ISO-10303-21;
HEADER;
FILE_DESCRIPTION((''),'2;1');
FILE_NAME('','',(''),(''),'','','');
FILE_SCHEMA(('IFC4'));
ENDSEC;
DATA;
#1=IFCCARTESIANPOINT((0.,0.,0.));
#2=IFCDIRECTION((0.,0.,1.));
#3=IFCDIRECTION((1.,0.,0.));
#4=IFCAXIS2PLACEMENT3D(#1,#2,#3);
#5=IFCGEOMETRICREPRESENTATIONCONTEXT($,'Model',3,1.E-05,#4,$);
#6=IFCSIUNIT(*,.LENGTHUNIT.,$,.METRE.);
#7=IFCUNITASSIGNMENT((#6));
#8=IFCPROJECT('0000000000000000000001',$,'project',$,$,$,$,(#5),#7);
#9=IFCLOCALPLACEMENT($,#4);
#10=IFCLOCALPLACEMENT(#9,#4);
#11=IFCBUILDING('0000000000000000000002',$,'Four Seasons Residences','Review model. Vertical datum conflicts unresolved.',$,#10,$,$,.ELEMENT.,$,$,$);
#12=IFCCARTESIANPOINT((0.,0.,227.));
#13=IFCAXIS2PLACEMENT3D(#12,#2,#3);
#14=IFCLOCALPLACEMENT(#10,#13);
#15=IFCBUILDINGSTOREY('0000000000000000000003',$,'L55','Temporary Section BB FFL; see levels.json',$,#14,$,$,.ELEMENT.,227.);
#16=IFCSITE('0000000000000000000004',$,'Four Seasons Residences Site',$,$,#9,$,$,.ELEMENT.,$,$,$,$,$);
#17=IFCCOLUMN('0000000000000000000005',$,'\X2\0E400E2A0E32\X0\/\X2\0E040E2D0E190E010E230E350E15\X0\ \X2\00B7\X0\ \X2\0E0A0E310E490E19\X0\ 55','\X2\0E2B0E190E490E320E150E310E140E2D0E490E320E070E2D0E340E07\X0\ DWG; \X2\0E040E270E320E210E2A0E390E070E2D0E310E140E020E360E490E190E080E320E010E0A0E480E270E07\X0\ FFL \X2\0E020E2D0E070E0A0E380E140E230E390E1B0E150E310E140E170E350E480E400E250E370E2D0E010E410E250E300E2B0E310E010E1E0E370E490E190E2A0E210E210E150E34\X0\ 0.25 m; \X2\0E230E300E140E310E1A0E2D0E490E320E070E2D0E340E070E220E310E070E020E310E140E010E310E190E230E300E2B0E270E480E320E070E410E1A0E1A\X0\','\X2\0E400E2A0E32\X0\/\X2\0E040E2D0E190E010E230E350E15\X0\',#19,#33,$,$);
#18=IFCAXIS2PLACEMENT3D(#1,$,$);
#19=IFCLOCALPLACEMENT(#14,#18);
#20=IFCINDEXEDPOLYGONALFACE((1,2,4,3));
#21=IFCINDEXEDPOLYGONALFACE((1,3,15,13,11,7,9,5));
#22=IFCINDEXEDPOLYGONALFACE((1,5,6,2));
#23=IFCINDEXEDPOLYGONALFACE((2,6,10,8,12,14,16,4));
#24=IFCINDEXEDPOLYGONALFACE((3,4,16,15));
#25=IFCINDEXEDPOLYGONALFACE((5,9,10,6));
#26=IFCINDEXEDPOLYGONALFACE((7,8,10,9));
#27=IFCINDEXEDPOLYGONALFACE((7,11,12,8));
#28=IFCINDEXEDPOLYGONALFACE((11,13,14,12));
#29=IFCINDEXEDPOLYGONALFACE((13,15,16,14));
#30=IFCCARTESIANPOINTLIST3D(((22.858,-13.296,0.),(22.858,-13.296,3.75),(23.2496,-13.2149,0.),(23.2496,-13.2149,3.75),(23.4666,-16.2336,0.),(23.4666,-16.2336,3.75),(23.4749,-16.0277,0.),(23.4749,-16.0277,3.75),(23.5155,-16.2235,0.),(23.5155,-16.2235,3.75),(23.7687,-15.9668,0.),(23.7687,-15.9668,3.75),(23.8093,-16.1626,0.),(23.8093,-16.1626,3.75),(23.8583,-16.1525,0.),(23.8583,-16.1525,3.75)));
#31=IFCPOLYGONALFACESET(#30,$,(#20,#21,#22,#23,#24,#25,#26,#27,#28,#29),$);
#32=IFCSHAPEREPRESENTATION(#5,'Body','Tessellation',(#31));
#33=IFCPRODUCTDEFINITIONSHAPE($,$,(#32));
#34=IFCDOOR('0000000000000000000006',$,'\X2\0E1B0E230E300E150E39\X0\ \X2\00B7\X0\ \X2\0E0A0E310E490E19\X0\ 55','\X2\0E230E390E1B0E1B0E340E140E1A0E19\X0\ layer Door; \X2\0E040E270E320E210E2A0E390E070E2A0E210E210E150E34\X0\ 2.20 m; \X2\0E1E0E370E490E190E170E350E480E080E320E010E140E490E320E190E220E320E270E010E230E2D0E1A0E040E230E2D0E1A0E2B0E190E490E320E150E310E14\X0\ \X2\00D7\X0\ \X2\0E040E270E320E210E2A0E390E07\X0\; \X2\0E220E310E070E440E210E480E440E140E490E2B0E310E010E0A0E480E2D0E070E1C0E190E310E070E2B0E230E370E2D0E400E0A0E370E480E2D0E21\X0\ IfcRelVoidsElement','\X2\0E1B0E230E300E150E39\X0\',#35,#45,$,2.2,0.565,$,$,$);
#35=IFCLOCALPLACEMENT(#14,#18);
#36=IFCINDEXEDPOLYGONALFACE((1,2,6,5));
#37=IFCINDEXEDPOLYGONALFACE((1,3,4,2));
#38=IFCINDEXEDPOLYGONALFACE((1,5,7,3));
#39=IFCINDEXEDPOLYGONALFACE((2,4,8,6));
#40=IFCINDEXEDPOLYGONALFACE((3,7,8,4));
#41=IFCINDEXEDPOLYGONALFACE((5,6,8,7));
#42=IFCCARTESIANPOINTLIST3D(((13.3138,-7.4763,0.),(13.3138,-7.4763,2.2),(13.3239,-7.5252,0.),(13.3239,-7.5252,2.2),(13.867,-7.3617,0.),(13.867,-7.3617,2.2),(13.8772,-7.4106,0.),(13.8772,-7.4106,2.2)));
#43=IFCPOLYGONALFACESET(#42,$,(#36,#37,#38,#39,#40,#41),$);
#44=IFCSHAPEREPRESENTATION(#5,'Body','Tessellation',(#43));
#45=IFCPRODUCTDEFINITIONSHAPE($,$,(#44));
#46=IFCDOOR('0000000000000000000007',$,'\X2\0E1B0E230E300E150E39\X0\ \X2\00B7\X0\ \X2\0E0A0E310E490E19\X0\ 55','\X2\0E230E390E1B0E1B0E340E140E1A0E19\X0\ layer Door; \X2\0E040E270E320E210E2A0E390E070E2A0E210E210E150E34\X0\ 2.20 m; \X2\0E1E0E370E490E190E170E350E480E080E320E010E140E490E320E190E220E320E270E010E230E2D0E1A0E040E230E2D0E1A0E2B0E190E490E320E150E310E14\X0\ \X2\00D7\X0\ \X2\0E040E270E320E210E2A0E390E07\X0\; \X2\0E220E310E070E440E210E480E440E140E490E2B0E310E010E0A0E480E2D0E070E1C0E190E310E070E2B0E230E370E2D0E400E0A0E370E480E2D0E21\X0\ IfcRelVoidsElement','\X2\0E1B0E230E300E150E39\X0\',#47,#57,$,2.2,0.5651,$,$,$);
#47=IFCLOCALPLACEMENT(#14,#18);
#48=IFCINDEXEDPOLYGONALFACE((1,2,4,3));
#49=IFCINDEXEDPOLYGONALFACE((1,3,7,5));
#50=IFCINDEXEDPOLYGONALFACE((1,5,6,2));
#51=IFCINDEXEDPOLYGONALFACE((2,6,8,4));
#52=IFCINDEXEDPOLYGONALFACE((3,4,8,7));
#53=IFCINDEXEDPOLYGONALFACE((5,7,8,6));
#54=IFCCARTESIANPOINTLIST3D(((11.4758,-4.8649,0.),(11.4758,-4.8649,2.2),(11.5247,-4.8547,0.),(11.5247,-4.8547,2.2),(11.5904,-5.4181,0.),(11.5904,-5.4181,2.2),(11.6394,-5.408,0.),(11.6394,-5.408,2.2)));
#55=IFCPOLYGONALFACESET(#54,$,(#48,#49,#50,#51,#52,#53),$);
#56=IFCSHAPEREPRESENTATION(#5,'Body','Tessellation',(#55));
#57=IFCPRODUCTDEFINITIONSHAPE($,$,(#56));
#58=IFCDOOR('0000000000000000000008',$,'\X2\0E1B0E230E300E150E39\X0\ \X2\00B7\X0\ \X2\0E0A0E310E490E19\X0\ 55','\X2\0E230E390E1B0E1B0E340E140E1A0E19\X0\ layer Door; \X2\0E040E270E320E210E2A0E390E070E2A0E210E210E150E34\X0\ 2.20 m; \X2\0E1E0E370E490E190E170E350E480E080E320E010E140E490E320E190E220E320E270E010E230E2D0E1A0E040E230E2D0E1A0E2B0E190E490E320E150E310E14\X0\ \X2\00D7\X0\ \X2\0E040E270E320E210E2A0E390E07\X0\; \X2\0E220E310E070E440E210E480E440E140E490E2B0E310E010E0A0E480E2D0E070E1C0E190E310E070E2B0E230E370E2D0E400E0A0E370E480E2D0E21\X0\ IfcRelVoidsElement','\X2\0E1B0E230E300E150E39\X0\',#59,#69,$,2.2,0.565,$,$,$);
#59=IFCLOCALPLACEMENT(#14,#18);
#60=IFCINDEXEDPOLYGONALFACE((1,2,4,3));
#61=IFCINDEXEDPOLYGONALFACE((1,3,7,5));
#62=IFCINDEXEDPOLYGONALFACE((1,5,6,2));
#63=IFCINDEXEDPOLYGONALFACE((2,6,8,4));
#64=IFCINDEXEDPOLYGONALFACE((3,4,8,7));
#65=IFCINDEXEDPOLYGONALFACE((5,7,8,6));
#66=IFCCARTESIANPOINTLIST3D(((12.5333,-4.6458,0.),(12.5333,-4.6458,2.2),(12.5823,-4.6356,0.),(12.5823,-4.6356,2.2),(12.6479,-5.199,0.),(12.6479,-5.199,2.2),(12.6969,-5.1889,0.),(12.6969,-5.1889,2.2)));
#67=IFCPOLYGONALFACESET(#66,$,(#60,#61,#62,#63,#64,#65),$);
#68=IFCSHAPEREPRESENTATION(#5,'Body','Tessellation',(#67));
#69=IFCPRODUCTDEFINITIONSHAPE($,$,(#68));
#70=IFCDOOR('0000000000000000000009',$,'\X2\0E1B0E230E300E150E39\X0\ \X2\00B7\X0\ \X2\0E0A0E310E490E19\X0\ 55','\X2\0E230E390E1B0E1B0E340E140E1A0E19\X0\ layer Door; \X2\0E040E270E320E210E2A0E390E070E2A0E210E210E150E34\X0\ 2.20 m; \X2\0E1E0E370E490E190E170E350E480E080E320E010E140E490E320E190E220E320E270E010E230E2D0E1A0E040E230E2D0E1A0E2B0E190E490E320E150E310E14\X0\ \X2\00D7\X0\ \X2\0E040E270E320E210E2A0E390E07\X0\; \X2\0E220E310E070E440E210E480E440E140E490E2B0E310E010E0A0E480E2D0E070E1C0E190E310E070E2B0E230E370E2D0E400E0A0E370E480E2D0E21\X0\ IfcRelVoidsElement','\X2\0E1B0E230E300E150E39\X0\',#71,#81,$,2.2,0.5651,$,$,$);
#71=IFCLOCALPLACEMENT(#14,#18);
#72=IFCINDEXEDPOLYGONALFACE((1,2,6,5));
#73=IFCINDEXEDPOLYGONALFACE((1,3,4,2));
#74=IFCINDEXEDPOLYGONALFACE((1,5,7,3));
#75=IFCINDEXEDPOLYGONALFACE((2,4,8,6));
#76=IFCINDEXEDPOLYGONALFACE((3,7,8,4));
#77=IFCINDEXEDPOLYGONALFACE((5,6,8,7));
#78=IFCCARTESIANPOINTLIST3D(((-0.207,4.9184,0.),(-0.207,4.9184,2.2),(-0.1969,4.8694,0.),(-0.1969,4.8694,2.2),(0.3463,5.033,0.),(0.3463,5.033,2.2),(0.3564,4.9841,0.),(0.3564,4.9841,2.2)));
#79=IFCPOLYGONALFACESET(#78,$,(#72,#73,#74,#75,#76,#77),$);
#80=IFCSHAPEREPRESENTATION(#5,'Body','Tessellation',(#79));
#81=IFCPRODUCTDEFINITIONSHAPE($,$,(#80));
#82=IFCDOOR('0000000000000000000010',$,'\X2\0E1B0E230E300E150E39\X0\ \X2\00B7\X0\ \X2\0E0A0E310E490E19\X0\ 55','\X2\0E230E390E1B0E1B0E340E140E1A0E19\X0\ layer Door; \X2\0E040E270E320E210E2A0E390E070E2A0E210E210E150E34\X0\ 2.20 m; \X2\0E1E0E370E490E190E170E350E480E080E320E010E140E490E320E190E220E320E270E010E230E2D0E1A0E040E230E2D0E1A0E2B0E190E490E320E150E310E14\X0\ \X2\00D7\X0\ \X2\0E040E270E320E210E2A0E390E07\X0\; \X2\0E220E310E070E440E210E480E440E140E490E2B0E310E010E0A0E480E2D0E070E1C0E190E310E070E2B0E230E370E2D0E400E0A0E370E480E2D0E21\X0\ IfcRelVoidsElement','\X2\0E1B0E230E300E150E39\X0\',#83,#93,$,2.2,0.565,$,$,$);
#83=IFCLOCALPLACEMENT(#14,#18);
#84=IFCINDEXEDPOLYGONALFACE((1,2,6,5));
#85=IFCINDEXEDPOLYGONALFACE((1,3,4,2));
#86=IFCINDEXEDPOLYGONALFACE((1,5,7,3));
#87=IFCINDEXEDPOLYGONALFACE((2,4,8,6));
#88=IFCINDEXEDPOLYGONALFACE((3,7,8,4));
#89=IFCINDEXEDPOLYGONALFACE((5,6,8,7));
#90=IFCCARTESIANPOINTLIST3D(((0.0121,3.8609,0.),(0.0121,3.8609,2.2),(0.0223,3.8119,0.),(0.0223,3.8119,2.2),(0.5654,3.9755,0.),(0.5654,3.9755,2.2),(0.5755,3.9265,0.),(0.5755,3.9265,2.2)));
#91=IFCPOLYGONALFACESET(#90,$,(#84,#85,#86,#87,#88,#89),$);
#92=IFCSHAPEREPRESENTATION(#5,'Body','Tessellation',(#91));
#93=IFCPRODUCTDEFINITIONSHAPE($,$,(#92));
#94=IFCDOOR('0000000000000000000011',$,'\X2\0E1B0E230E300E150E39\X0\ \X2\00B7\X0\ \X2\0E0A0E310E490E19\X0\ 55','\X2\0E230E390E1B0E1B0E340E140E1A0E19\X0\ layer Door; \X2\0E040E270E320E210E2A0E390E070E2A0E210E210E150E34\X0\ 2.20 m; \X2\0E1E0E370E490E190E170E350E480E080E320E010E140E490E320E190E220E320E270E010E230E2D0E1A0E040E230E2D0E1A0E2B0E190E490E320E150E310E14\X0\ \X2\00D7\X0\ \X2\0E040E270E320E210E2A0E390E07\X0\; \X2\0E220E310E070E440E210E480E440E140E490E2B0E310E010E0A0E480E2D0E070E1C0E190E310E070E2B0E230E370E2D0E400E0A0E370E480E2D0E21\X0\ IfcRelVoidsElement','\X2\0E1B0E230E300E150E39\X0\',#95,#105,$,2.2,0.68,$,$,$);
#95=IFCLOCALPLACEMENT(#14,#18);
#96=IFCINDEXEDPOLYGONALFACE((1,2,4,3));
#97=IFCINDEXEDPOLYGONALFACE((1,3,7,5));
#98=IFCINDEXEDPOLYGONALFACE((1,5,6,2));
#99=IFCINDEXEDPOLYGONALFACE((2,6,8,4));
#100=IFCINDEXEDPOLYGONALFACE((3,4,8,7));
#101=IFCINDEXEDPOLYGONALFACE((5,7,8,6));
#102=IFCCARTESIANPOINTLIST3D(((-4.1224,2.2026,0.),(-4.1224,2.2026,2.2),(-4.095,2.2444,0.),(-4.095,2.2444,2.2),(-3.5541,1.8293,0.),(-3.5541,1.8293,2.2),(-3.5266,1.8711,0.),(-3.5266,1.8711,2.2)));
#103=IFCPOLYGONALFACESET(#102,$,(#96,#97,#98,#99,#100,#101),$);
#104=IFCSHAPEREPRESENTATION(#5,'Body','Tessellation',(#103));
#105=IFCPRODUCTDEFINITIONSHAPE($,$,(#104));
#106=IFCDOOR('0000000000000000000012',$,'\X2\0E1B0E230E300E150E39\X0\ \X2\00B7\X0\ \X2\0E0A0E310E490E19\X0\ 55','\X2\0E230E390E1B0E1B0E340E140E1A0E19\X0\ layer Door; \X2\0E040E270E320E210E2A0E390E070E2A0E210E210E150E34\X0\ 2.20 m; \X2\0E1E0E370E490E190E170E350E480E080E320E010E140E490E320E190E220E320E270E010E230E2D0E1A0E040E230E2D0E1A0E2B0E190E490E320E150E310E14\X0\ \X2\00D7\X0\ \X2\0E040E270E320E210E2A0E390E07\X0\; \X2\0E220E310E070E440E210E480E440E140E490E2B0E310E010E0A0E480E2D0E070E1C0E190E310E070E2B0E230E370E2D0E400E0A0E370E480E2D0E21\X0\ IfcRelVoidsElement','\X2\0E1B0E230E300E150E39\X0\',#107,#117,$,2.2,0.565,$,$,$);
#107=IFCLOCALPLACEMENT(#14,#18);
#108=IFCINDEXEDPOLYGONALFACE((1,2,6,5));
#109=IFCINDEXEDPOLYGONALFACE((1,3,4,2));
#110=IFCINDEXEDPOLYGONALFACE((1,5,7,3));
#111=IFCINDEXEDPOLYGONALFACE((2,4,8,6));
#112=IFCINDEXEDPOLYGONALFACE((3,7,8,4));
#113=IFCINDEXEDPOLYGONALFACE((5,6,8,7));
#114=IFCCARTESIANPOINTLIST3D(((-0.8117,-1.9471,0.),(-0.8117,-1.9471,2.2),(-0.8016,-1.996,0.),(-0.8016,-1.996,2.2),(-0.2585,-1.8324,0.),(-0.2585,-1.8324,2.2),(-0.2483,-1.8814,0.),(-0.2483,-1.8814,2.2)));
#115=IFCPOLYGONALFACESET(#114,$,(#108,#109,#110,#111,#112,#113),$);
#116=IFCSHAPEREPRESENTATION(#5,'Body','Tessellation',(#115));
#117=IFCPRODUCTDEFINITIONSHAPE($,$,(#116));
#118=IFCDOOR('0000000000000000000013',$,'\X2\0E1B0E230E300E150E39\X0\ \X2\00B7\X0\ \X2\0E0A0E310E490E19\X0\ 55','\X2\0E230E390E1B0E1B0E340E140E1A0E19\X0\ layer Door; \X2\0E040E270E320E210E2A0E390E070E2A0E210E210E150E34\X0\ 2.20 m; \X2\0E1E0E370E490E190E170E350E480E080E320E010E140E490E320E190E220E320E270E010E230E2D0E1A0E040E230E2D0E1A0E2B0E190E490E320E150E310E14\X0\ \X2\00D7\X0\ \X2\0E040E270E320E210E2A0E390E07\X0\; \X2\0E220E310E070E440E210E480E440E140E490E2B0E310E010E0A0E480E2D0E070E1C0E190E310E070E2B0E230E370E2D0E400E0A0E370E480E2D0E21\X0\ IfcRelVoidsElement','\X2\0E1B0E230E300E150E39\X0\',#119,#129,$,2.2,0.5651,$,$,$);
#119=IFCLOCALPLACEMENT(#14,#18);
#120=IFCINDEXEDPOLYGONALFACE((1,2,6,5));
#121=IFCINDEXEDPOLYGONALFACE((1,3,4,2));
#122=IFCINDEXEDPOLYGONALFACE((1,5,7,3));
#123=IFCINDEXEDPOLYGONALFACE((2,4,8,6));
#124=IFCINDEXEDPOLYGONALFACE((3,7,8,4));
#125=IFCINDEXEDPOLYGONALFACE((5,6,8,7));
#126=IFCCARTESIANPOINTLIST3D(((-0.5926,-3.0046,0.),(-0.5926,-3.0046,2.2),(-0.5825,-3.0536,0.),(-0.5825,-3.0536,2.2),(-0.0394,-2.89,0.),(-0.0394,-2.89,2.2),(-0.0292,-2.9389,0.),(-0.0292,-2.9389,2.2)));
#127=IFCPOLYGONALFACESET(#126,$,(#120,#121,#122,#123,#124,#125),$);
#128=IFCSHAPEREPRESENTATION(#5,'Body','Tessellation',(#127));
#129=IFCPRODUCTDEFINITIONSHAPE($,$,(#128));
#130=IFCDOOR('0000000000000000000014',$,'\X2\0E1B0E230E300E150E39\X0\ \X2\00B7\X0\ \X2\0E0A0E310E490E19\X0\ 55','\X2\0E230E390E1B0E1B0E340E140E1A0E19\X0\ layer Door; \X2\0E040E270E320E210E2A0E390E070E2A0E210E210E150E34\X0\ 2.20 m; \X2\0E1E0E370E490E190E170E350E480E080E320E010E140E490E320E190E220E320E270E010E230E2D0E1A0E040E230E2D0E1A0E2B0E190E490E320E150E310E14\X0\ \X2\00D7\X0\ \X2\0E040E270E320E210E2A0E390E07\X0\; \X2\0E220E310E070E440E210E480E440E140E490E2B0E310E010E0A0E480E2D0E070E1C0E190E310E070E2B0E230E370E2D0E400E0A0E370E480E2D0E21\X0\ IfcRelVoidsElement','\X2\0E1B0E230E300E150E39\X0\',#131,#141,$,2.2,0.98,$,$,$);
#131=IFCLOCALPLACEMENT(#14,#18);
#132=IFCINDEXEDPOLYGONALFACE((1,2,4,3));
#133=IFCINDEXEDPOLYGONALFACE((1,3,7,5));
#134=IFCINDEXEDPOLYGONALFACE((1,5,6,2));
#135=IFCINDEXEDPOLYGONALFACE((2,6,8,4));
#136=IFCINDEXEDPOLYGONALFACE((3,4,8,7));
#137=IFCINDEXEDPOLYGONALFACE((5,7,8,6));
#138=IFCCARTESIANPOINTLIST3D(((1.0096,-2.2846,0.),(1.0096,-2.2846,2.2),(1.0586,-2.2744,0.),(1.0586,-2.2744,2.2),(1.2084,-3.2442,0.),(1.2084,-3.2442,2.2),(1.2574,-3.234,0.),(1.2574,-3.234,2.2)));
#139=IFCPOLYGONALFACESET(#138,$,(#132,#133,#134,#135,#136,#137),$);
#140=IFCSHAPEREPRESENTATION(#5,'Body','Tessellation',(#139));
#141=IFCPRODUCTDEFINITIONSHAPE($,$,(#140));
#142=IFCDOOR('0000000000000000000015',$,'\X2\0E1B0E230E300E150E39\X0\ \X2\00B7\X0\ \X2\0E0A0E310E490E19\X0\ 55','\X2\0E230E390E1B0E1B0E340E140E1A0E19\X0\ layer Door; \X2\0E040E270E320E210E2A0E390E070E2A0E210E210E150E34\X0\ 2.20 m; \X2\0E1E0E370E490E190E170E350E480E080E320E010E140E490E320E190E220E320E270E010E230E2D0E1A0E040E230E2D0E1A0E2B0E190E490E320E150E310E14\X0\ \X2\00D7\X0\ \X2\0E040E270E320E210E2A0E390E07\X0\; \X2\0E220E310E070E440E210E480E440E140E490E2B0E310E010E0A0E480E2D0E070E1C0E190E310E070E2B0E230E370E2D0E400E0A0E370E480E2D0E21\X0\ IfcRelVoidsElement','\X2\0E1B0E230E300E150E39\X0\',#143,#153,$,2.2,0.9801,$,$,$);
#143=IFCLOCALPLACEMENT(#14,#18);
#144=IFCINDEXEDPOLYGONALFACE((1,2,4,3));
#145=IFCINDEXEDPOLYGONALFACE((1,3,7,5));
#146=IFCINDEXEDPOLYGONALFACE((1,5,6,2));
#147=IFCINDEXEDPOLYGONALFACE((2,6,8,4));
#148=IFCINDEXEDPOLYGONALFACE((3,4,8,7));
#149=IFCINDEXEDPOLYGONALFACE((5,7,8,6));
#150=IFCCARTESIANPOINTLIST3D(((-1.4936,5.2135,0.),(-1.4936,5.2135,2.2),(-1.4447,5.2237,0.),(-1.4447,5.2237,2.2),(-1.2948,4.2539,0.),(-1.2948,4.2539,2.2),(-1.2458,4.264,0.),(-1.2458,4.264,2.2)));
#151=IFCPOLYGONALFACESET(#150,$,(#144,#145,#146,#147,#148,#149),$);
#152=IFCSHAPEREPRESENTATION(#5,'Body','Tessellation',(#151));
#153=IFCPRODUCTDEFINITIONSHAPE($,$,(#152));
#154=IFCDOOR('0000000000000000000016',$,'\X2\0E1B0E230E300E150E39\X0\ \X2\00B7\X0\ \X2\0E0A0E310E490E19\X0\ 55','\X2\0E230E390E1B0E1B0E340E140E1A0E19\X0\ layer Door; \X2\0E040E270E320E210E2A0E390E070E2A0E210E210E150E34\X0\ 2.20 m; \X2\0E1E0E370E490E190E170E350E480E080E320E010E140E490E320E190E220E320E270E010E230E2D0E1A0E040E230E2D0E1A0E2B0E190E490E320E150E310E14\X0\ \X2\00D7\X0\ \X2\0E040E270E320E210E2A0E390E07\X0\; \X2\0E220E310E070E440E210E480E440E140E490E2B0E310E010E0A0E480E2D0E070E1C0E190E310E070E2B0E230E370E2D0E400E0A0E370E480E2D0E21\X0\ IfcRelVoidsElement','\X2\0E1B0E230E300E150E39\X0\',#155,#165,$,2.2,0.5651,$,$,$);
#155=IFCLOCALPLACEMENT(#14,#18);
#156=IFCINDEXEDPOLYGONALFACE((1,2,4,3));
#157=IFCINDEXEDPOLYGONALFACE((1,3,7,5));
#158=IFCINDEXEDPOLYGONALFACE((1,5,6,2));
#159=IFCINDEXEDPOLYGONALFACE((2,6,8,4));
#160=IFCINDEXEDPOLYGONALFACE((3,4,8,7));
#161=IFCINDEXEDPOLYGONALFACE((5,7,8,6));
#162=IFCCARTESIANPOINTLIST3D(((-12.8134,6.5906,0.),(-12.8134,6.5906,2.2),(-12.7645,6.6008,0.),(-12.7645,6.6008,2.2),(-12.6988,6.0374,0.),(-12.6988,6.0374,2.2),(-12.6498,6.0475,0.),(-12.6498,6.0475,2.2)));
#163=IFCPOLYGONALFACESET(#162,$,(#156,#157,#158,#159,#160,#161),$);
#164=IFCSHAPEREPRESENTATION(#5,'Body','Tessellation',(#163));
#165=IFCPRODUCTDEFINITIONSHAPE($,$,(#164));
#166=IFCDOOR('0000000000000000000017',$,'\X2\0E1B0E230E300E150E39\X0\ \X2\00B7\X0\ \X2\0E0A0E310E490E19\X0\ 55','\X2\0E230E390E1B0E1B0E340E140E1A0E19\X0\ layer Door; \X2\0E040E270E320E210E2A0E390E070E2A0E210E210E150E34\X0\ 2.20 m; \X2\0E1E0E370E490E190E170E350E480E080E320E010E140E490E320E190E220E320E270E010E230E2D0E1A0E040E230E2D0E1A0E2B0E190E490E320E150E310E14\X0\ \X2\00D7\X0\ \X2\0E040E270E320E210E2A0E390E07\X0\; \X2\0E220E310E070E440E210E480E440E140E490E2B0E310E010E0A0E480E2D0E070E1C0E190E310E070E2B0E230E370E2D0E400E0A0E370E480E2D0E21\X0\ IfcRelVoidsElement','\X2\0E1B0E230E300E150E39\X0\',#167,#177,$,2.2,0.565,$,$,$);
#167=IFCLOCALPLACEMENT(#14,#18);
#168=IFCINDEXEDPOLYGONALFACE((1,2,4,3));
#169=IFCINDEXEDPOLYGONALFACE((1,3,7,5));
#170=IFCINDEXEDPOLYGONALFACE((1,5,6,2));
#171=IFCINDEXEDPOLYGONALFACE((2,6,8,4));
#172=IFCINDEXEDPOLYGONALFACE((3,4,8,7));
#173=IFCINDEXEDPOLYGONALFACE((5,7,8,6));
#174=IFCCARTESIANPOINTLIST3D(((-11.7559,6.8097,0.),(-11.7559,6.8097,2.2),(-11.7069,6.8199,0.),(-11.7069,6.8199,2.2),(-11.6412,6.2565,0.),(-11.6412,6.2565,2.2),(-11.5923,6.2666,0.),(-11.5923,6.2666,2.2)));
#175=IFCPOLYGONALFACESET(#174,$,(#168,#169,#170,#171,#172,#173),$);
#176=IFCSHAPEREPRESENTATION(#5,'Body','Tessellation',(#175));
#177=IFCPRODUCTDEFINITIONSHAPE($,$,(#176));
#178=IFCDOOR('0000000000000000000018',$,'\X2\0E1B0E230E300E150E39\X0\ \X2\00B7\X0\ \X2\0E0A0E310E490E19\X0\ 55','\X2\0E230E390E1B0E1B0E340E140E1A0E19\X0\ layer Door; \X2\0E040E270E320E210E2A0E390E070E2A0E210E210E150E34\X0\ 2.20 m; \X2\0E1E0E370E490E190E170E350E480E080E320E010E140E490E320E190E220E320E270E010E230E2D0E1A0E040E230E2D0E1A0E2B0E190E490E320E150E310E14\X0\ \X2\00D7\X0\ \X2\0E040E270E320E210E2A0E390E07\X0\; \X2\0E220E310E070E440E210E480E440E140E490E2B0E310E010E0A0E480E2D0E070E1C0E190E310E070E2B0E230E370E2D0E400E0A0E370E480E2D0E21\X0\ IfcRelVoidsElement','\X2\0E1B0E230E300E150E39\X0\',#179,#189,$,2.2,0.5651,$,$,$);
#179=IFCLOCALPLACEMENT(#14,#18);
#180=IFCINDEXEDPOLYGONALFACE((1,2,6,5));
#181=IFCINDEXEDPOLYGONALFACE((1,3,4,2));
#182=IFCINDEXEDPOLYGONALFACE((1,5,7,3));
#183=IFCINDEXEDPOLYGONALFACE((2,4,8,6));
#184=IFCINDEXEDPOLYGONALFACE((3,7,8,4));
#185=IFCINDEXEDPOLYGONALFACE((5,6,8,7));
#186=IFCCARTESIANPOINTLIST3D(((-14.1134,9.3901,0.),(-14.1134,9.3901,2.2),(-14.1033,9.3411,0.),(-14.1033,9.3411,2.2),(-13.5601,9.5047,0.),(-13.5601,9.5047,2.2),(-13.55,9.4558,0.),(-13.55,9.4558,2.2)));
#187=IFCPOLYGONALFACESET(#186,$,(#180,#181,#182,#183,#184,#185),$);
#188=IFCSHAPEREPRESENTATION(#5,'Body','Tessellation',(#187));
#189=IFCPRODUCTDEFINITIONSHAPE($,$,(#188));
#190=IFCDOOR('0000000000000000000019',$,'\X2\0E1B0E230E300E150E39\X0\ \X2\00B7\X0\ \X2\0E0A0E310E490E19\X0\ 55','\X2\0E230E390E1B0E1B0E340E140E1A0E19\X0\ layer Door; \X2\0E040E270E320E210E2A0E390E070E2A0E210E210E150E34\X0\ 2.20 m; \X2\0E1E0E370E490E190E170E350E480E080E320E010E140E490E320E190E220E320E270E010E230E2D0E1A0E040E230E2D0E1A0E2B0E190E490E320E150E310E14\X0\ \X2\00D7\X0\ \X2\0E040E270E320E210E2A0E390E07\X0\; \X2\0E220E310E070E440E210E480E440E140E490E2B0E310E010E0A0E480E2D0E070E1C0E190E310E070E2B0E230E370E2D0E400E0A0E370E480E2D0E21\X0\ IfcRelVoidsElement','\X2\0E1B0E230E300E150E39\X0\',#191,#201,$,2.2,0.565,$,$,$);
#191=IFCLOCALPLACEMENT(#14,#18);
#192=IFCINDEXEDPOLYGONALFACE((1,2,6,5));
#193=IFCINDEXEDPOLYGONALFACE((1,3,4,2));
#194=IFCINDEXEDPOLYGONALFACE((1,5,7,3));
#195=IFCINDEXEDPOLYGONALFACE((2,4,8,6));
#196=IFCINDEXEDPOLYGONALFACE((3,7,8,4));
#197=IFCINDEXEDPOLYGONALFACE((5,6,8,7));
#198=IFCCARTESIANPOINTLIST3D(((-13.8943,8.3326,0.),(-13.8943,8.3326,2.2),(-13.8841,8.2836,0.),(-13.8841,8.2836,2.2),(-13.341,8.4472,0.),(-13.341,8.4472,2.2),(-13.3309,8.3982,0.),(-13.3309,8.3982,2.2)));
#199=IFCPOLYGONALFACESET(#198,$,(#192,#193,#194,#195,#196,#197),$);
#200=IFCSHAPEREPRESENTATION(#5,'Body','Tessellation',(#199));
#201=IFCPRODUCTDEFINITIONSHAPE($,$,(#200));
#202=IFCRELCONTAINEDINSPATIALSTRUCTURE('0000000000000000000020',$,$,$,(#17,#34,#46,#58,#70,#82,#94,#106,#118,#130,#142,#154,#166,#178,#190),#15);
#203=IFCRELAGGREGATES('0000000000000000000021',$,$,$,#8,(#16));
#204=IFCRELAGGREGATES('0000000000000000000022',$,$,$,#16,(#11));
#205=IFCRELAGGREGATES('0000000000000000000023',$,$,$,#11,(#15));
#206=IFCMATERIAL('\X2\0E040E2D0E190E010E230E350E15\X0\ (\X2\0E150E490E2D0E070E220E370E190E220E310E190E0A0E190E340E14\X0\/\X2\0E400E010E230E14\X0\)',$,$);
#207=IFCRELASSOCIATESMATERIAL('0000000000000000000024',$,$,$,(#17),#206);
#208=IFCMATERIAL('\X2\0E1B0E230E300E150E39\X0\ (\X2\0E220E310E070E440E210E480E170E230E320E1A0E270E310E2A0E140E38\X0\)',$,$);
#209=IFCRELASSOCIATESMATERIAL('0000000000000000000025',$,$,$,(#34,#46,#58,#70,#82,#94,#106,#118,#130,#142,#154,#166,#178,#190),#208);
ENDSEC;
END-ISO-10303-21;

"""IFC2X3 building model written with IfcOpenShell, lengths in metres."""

from ifc_helpers import new_model, si_unit, frame, origin_with_axes, place, context, project, spatial, polyline, outline, extrude, material, element, save


model = new_model("IFC2X3")

# Units and contexts
model_context = context("Model", 3, precision=1e-05, world=origin_with_axes())
ifc_project = project(units=[si_unit("LENGTHUNIT", "METRE")], contexts=[model_context])

# Site, building, storey
site_placement = place(None, origin_with_axes())
site = spatial("IfcSite", under=ifc_project, at=site_placement, Name="Four Seasons Residences Site", CompositionType="ELEMENT")
building_placement = place(site_placement, origin_with_axes())
building = spatial("IfcBuilding", under=site, at=building_placement, Name="Four Seasons Residences", Description="Review model. Vertical datum conflicts unresolved.", CompositionType="ELEMENT")
storey_placement = place(building_placement, frame((0.0, 0.0, 227.0), z_axis=(0.0, 0.0, 1.0), x_axis=(1.0, 0.0, 0.0)))
storey = spatial("IfcBuildingStorey", under=building, at=storey_placement, Name="L55", Description="Temporary Section BB FFL; see levels.json", CompositionType="ELEMENT", Elevation=227.0)

# Column
ifc_material_1 = material(Name="คอนกรีต (ต้องยืนยันชนิด/เกรด)")
column_placement = place(storey_placement, origin_with_axes())
element("IfcColumn", 1, at=column_placement, inside=storey, material=ifc_material_1, Name="เสา/คอนกรีต · ชั้น 55", Description="หน้าตัดอ้างอิง DWG; ความสูงอัดขึ้นจากช่วง FFL ของชุดรูปตัดที่เลือกและหักพื้นสมมติ 0.25 m; ระดับอ้างอิงยังขัดกันระหว่างแบบ", ObjectType="เสา/คอนกรีต", context=model_context, shape_type="SweptSolid", body=[
    extrude(outline(polyline([(23.8583, -16.1525), (23.8093, -16.1626), (23.7687, -15.9668), (23.4749, -16.0277), (23.5155, -16.2235), (23.4666, -16.2336), (22.858, -13.296), (23.2496, -13.2149), (23.8583, -16.1525)])), origin_with_axes(), (0.0, 0.0, 1.0), 3.75),
])

# Doors
ifc_material_2 = material(Name="ประตู (ยังไม่ทราบวัสดุ)")
door_1_placement = place(storey_placement, origin_with_axes())
element("IfcDoor", 2, at=door_1_placement, inside=storey, material=ifc_material_2, Name="ประตู · ชั้น 55", Description="รูปปิดบน layer Door; ความสูงสมมติ 2.20 m; พื้นที่จากด้านยาวกรอบครอบหน้าตัด × ความสูง; ยังไม่ได้หักช่องผนังหรือเชื่อม IfcRelVoidsElement", ObjectType="ประตู", OverallHeight=2.2, OverallWidth=0.565, context=model_context, shape_type="SweptSolid", body=[
    extrude(outline(polyline([(13.3239, -7.5252), (13.8772, -7.4106), (13.867, -7.3617), (13.3138, -7.4763), (13.3239, -7.5252)])), origin_with_axes(), (0.0, 0.0, 1.0), 2.2),
])
door_2_placement = place(storey_placement, origin_with_axes())
element("IfcDoor", 3, at=door_2_placement, inside=storey, material=ifc_material_2, Name="ประตู · ชั้น 55", Description="รูปปิดบน layer Door; ความสูงสมมติ 2.20 m; พื้นที่จากด้านยาวกรอบครอบหน้าตัด × ความสูง; ยังไม่ได้หักช่องผนังหรือเชื่อม IfcRelVoidsElement", ObjectType="ประตู", OverallHeight=2.2, OverallWidth=0.5651, context=model_context, shape_type="SweptSolid", body=[
    extrude(outline(polyline([(11.4758, -4.8649), (11.5904, -5.4181), (11.6394, -5.408), (11.5247, -4.8547), (11.4758, -4.8649)])), origin_with_axes(), (0.0, 0.0, 1.0), 2.2),
])
door_3_placement = place(storey_placement, origin_with_axes())
element("IfcDoor", 4, at=door_3_placement, inside=storey, material=ifc_material_2, Name="ประตู · ชั้น 55", Description="รูปปิดบน layer Door; ความสูงสมมติ 2.20 m; พื้นที่จากด้านยาวกรอบครอบหน้าตัด × ความสูง; ยังไม่ได้หักช่องผนังหรือเชื่อม IfcRelVoidsElement", ObjectType="ประตู", OverallHeight=2.2, OverallWidth=0.565, context=model_context, shape_type="SweptSolid", body=[
    extrude(outline(polyline([(12.5823, -4.6356), (12.6969, -5.1889), (12.6479, -5.199), (12.5333, -4.6458), (12.5823, -4.6356)])), origin_with_axes(), (0.0, 0.0, 1.0), 2.2),
])
door_4_placement = place(storey_placement, origin_with_axes())
element("IfcDoor", 5, at=door_4_placement, inside=storey, material=ifc_material_2, Name="ประตู · ชั้น 55", Description="รูปปิดบน layer Door; ความสูงสมมติ 2.20 m; พื้นที่จากด้านยาวกรอบครอบหน้าตัด × ความสูง; ยังไม่ได้หักช่องผนังหรือเชื่อม IfcRelVoidsElement", ObjectType="ประตู", OverallHeight=2.2, OverallWidth=0.5651, context=model_context, shape_type="SweptSolid", body=[
    extrude(outline(polyline([(-0.207, 4.9184), (0.3463, 5.033), (0.3564, 4.9841), (-0.1969, 4.8694), (-0.207, 4.9184)])), origin_with_axes(), (0.0, 0.0, 1.0), 2.2),
])
door_5_placement = place(storey_placement, origin_with_axes())
element("IfcDoor", 6, at=door_5_placement, inside=storey, material=ifc_material_2, Name="ประตู · ชั้น 55", Description="รูปปิดบน layer Door; ความสูงสมมติ 2.20 m; พื้นที่จากด้านยาวกรอบครอบหน้าตัด × ความสูง; ยังไม่ได้หักช่องผนังหรือเชื่อม IfcRelVoidsElement", ObjectType="ประตู", OverallHeight=2.2, OverallWidth=0.565, context=model_context, shape_type="SweptSolid", body=[
    extrude(outline(polyline([(0.0223, 3.8119), (0.5755, 3.9265), (0.5654, 3.9755), (0.0121, 3.8609), (0.0223, 3.8119)])), origin_with_axes(), (0.0, 0.0, 1.0), 2.2),
])
door_6_placement = place(storey_placement, origin_with_axes())
element("IfcDoor", 7, at=door_6_placement, inside=storey, material=ifc_material_2, Name="ประตู · ชั้น 55", Description="รูปปิดบน layer Door; ความสูงสมมติ 2.20 m; พื้นที่จากด้านยาวกรอบครอบหน้าตัด × ความสูง; ยังไม่ได้หักช่องผนังหรือเชื่อม IfcRelVoidsElement", ObjectType="ประตู", OverallHeight=2.2, OverallWidth=0.68, context=model_context, shape_type="SweptSolid", body=[
    extrude(outline(polyline([(-3.5541, 1.8293), (-4.1224, 2.2026), (-4.095, 2.2444), (-3.5266, 1.8711), (-3.5541, 1.8293)])), origin_with_axes(), (0.0, 0.0, 1.0), 2.2),
])
door_7_placement = place(storey_placement, origin_with_axes())
element("IfcDoor", 8, at=door_7_placement, inside=storey, material=ifc_material_2, Name="ประตู · ชั้น 55", Description="รูปปิดบน layer Door; ความสูงสมมติ 2.20 m; พื้นที่จากด้านยาวกรอบครอบหน้าตัด × ความสูง; ยังไม่ได้หักช่องผนังหรือเชื่อม IfcRelVoidsElement", ObjectType="ประตู", OverallHeight=2.2, OverallWidth=0.565, context=model_context, shape_type="SweptSolid", body=[
    extrude(outline(polyline([(-0.2585, -1.8324), (-0.8117, -1.9471), (-0.8016, -1.996), (-0.2483, -1.8814), (-0.2585, -1.8324)])), origin_with_axes(), (0.0, 0.0, 1.0), 2.2),
])
door_8_placement = place(storey_placement, origin_with_axes())
element("IfcDoor", 9, at=door_8_placement, inside=storey, material=ifc_material_2, Name="ประตู · ชั้น 55", Description="รูปปิดบน layer Door; ความสูงสมมติ 2.20 m; พื้นที่จากด้านยาวกรอบครอบหน้าตัด × ความสูง; ยังไม่ได้หักช่องผนังหรือเชื่อม IfcRelVoidsElement", ObjectType="ประตู", OverallHeight=2.2, OverallWidth=0.5651, context=model_context, shape_type="SweptSolid", body=[
    extrude(outline(polyline([(-0.0292, -2.9389), (-0.5825, -3.0536), (-0.5926, -3.0046), (-0.0394, -2.89), (-0.0292, -2.9389)])), origin_with_axes(), (0.0, 0.0, 1.0), 2.2),
])
door_9_placement = place(storey_placement, origin_with_axes())
element("IfcDoor", 10, at=door_9_placement, inside=storey, material=ifc_material_2, Name="ประตู · ชั้น 55", Description="รูปปิดบน layer Door; ความสูงสมมติ 2.20 m; พื้นที่จากด้านยาวกรอบครอบหน้าตัด × ความสูง; ยังไม่ได้หักช่องผนังหรือเชื่อม IfcRelVoidsElement", ObjectType="ประตู", OverallHeight=2.2, OverallWidth=0.98, context=model_context, shape_type="SweptSolid", body=[
    extrude(outline(polyline([(1.2574, -3.234), (1.2084, -3.2442), (1.0096, -2.2846), (1.0586, -2.2744), (1.2574, -3.234)])), origin_with_axes(), (0.0, 0.0, 1.0), 2.2),
])
door_10_placement = place(storey_placement, origin_with_axes())
element("IfcDoor", 11, at=door_10_placement, inside=storey, material=ifc_material_2, Name="ประตู · ชั้น 55", Description="รูปปิดบน layer Door; ความสูงสมมติ 2.20 m; พื้นที่จากด้านยาวกรอบครอบหน้าตัด × ความสูง; ยังไม่ได้หักช่องผนังหรือเชื่อม IfcRelVoidsElement", ObjectType="ประตู", OverallHeight=2.2, OverallWidth=0.9801, context=model_context, shape_type="SweptSolid", body=[
    extrude(outline(polyline([(-1.4936, 5.2135), (-1.4447, 5.2237), (-1.2458, 4.264), (-1.2948, 4.2539), (-1.4936, 5.2135)])), origin_with_axes(), (0.0, 0.0, 1.0), 2.2),
])
door_11_placement = place(storey_placement, origin_with_axes())
element("IfcDoor", 12, at=door_11_placement, inside=storey, material=ifc_material_2, Name="ประตู · ชั้น 55", Description="รูปปิดบน layer Door; ความสูงสมมติ 2.20 m; พื้นที่จากด้านยาวกรอบครอบหน้าตัด × ความสูง; ยังไม่ได้หักช่องผนังหรือเชื่อม IfcRelVoidsElement", ObjectType="ประตู", OverallHeight=2.2, OverallWidth=0.5651, context=model_context, shape_type="SweptSolid", body=[
    extrude(outline(polyline([(-12.6988, 6.0374), (-12.8134, 6.5906), (-12.7645, 6.6008), (-12.6498, 6.0475), (-12.6988, 6.0374)])), origin_with_axes(), (0.0, 0.0, 1.0), 2.2),
])
door_12_placement = place(storey_placement, origin_with_axes())
element("IfcDoor", 13, at=door_12_placement, inside=storey, material=ifc_material_2, Name="ประตู · ชั้น 55", Description="รูปปิดบน layer Door; ความสูงสมมติ 2.20 m; พื้นที่จากด้านยาวกรอบครอบหน้าตัด × ความสูง; ยังไม่ได้หักช่องผนังหรือเชื่อม IfcRelVoidsElement", ObjectType="ประตู", OverallHeight=2.2, OverallWidth=0.565, context=model_context, shape_type="SweptSolid", body=[
    extrude(outline(polyline([(-11.5923, 6.2666), (-11.7069, 6.8199), (-11.7559, 6.8097), (-11.6412, 6.2565), (-11.5923, 6.2666)])), origin_with_axes(), (0.0, 0.0, 1.0), 2.2),
])
door_13_placement = place(storey_placement, origin_with_axes())
element("IfcDoor", 14, at=door_13_placement, inside=storey, material=ifc_material_2, Name="ประตู · ชั้น 55", Description="รูปปิดบน layer Door; ความสูงสมมติ 2.20 m; พื้นที่จากด้านยาวกรอบครอบหน้าตัด × ความสูง; ยังไม่ได้หักช่องผนังหรือเชื่อม IfcRelVoidsElement", ObjectType="ประตู", OverallHeight=2.2, OverallWidth=0.5651, context=model_context, shape_type="SweptSolid", body=[
    extrude(outline(polyline([(-13.5601, 9.5047), (-14.1134, 9.3901), (-14.1033, 9.3411), (-13.55, 9.4558), (-13.5601, 9.5047)])), origin_with_axes(), (0.0, 0.0, 1.0), 2.2),
])
door_14_placement = place(storey_placement, origin_with_axes())
element("IfcDoor", 15, at=door_14_placement, inside=storey, material=ifc_material_2, Name="ประตู · ชั้น 55", Description="รูปปิดบน layer Door; ความสูงสมมติ 2.20 m; พื้นที่จากด้านยาวกรอบครอบหน้าตัด × ความสูง; ยังไม่ได้หักช่องผนังหรือเชื่อม IfcRelVoidsElement", ObjectType="ประตู", OverallHeight=2.2, OverallWidth=0.565, context=model_context, shape_type="SweptSolid", body=[
    extrude(outline(polyline([(-13.3309, 8.3982), (-13.8841, 8.2836), (-13.8943, 8.3326), (-13.341, 8.4472), (-13.3309, 8.3982)])), origin_with_axes(), (0.0, 0.0, 1.0), 2.2),
])

save(model, "model.ifc")
